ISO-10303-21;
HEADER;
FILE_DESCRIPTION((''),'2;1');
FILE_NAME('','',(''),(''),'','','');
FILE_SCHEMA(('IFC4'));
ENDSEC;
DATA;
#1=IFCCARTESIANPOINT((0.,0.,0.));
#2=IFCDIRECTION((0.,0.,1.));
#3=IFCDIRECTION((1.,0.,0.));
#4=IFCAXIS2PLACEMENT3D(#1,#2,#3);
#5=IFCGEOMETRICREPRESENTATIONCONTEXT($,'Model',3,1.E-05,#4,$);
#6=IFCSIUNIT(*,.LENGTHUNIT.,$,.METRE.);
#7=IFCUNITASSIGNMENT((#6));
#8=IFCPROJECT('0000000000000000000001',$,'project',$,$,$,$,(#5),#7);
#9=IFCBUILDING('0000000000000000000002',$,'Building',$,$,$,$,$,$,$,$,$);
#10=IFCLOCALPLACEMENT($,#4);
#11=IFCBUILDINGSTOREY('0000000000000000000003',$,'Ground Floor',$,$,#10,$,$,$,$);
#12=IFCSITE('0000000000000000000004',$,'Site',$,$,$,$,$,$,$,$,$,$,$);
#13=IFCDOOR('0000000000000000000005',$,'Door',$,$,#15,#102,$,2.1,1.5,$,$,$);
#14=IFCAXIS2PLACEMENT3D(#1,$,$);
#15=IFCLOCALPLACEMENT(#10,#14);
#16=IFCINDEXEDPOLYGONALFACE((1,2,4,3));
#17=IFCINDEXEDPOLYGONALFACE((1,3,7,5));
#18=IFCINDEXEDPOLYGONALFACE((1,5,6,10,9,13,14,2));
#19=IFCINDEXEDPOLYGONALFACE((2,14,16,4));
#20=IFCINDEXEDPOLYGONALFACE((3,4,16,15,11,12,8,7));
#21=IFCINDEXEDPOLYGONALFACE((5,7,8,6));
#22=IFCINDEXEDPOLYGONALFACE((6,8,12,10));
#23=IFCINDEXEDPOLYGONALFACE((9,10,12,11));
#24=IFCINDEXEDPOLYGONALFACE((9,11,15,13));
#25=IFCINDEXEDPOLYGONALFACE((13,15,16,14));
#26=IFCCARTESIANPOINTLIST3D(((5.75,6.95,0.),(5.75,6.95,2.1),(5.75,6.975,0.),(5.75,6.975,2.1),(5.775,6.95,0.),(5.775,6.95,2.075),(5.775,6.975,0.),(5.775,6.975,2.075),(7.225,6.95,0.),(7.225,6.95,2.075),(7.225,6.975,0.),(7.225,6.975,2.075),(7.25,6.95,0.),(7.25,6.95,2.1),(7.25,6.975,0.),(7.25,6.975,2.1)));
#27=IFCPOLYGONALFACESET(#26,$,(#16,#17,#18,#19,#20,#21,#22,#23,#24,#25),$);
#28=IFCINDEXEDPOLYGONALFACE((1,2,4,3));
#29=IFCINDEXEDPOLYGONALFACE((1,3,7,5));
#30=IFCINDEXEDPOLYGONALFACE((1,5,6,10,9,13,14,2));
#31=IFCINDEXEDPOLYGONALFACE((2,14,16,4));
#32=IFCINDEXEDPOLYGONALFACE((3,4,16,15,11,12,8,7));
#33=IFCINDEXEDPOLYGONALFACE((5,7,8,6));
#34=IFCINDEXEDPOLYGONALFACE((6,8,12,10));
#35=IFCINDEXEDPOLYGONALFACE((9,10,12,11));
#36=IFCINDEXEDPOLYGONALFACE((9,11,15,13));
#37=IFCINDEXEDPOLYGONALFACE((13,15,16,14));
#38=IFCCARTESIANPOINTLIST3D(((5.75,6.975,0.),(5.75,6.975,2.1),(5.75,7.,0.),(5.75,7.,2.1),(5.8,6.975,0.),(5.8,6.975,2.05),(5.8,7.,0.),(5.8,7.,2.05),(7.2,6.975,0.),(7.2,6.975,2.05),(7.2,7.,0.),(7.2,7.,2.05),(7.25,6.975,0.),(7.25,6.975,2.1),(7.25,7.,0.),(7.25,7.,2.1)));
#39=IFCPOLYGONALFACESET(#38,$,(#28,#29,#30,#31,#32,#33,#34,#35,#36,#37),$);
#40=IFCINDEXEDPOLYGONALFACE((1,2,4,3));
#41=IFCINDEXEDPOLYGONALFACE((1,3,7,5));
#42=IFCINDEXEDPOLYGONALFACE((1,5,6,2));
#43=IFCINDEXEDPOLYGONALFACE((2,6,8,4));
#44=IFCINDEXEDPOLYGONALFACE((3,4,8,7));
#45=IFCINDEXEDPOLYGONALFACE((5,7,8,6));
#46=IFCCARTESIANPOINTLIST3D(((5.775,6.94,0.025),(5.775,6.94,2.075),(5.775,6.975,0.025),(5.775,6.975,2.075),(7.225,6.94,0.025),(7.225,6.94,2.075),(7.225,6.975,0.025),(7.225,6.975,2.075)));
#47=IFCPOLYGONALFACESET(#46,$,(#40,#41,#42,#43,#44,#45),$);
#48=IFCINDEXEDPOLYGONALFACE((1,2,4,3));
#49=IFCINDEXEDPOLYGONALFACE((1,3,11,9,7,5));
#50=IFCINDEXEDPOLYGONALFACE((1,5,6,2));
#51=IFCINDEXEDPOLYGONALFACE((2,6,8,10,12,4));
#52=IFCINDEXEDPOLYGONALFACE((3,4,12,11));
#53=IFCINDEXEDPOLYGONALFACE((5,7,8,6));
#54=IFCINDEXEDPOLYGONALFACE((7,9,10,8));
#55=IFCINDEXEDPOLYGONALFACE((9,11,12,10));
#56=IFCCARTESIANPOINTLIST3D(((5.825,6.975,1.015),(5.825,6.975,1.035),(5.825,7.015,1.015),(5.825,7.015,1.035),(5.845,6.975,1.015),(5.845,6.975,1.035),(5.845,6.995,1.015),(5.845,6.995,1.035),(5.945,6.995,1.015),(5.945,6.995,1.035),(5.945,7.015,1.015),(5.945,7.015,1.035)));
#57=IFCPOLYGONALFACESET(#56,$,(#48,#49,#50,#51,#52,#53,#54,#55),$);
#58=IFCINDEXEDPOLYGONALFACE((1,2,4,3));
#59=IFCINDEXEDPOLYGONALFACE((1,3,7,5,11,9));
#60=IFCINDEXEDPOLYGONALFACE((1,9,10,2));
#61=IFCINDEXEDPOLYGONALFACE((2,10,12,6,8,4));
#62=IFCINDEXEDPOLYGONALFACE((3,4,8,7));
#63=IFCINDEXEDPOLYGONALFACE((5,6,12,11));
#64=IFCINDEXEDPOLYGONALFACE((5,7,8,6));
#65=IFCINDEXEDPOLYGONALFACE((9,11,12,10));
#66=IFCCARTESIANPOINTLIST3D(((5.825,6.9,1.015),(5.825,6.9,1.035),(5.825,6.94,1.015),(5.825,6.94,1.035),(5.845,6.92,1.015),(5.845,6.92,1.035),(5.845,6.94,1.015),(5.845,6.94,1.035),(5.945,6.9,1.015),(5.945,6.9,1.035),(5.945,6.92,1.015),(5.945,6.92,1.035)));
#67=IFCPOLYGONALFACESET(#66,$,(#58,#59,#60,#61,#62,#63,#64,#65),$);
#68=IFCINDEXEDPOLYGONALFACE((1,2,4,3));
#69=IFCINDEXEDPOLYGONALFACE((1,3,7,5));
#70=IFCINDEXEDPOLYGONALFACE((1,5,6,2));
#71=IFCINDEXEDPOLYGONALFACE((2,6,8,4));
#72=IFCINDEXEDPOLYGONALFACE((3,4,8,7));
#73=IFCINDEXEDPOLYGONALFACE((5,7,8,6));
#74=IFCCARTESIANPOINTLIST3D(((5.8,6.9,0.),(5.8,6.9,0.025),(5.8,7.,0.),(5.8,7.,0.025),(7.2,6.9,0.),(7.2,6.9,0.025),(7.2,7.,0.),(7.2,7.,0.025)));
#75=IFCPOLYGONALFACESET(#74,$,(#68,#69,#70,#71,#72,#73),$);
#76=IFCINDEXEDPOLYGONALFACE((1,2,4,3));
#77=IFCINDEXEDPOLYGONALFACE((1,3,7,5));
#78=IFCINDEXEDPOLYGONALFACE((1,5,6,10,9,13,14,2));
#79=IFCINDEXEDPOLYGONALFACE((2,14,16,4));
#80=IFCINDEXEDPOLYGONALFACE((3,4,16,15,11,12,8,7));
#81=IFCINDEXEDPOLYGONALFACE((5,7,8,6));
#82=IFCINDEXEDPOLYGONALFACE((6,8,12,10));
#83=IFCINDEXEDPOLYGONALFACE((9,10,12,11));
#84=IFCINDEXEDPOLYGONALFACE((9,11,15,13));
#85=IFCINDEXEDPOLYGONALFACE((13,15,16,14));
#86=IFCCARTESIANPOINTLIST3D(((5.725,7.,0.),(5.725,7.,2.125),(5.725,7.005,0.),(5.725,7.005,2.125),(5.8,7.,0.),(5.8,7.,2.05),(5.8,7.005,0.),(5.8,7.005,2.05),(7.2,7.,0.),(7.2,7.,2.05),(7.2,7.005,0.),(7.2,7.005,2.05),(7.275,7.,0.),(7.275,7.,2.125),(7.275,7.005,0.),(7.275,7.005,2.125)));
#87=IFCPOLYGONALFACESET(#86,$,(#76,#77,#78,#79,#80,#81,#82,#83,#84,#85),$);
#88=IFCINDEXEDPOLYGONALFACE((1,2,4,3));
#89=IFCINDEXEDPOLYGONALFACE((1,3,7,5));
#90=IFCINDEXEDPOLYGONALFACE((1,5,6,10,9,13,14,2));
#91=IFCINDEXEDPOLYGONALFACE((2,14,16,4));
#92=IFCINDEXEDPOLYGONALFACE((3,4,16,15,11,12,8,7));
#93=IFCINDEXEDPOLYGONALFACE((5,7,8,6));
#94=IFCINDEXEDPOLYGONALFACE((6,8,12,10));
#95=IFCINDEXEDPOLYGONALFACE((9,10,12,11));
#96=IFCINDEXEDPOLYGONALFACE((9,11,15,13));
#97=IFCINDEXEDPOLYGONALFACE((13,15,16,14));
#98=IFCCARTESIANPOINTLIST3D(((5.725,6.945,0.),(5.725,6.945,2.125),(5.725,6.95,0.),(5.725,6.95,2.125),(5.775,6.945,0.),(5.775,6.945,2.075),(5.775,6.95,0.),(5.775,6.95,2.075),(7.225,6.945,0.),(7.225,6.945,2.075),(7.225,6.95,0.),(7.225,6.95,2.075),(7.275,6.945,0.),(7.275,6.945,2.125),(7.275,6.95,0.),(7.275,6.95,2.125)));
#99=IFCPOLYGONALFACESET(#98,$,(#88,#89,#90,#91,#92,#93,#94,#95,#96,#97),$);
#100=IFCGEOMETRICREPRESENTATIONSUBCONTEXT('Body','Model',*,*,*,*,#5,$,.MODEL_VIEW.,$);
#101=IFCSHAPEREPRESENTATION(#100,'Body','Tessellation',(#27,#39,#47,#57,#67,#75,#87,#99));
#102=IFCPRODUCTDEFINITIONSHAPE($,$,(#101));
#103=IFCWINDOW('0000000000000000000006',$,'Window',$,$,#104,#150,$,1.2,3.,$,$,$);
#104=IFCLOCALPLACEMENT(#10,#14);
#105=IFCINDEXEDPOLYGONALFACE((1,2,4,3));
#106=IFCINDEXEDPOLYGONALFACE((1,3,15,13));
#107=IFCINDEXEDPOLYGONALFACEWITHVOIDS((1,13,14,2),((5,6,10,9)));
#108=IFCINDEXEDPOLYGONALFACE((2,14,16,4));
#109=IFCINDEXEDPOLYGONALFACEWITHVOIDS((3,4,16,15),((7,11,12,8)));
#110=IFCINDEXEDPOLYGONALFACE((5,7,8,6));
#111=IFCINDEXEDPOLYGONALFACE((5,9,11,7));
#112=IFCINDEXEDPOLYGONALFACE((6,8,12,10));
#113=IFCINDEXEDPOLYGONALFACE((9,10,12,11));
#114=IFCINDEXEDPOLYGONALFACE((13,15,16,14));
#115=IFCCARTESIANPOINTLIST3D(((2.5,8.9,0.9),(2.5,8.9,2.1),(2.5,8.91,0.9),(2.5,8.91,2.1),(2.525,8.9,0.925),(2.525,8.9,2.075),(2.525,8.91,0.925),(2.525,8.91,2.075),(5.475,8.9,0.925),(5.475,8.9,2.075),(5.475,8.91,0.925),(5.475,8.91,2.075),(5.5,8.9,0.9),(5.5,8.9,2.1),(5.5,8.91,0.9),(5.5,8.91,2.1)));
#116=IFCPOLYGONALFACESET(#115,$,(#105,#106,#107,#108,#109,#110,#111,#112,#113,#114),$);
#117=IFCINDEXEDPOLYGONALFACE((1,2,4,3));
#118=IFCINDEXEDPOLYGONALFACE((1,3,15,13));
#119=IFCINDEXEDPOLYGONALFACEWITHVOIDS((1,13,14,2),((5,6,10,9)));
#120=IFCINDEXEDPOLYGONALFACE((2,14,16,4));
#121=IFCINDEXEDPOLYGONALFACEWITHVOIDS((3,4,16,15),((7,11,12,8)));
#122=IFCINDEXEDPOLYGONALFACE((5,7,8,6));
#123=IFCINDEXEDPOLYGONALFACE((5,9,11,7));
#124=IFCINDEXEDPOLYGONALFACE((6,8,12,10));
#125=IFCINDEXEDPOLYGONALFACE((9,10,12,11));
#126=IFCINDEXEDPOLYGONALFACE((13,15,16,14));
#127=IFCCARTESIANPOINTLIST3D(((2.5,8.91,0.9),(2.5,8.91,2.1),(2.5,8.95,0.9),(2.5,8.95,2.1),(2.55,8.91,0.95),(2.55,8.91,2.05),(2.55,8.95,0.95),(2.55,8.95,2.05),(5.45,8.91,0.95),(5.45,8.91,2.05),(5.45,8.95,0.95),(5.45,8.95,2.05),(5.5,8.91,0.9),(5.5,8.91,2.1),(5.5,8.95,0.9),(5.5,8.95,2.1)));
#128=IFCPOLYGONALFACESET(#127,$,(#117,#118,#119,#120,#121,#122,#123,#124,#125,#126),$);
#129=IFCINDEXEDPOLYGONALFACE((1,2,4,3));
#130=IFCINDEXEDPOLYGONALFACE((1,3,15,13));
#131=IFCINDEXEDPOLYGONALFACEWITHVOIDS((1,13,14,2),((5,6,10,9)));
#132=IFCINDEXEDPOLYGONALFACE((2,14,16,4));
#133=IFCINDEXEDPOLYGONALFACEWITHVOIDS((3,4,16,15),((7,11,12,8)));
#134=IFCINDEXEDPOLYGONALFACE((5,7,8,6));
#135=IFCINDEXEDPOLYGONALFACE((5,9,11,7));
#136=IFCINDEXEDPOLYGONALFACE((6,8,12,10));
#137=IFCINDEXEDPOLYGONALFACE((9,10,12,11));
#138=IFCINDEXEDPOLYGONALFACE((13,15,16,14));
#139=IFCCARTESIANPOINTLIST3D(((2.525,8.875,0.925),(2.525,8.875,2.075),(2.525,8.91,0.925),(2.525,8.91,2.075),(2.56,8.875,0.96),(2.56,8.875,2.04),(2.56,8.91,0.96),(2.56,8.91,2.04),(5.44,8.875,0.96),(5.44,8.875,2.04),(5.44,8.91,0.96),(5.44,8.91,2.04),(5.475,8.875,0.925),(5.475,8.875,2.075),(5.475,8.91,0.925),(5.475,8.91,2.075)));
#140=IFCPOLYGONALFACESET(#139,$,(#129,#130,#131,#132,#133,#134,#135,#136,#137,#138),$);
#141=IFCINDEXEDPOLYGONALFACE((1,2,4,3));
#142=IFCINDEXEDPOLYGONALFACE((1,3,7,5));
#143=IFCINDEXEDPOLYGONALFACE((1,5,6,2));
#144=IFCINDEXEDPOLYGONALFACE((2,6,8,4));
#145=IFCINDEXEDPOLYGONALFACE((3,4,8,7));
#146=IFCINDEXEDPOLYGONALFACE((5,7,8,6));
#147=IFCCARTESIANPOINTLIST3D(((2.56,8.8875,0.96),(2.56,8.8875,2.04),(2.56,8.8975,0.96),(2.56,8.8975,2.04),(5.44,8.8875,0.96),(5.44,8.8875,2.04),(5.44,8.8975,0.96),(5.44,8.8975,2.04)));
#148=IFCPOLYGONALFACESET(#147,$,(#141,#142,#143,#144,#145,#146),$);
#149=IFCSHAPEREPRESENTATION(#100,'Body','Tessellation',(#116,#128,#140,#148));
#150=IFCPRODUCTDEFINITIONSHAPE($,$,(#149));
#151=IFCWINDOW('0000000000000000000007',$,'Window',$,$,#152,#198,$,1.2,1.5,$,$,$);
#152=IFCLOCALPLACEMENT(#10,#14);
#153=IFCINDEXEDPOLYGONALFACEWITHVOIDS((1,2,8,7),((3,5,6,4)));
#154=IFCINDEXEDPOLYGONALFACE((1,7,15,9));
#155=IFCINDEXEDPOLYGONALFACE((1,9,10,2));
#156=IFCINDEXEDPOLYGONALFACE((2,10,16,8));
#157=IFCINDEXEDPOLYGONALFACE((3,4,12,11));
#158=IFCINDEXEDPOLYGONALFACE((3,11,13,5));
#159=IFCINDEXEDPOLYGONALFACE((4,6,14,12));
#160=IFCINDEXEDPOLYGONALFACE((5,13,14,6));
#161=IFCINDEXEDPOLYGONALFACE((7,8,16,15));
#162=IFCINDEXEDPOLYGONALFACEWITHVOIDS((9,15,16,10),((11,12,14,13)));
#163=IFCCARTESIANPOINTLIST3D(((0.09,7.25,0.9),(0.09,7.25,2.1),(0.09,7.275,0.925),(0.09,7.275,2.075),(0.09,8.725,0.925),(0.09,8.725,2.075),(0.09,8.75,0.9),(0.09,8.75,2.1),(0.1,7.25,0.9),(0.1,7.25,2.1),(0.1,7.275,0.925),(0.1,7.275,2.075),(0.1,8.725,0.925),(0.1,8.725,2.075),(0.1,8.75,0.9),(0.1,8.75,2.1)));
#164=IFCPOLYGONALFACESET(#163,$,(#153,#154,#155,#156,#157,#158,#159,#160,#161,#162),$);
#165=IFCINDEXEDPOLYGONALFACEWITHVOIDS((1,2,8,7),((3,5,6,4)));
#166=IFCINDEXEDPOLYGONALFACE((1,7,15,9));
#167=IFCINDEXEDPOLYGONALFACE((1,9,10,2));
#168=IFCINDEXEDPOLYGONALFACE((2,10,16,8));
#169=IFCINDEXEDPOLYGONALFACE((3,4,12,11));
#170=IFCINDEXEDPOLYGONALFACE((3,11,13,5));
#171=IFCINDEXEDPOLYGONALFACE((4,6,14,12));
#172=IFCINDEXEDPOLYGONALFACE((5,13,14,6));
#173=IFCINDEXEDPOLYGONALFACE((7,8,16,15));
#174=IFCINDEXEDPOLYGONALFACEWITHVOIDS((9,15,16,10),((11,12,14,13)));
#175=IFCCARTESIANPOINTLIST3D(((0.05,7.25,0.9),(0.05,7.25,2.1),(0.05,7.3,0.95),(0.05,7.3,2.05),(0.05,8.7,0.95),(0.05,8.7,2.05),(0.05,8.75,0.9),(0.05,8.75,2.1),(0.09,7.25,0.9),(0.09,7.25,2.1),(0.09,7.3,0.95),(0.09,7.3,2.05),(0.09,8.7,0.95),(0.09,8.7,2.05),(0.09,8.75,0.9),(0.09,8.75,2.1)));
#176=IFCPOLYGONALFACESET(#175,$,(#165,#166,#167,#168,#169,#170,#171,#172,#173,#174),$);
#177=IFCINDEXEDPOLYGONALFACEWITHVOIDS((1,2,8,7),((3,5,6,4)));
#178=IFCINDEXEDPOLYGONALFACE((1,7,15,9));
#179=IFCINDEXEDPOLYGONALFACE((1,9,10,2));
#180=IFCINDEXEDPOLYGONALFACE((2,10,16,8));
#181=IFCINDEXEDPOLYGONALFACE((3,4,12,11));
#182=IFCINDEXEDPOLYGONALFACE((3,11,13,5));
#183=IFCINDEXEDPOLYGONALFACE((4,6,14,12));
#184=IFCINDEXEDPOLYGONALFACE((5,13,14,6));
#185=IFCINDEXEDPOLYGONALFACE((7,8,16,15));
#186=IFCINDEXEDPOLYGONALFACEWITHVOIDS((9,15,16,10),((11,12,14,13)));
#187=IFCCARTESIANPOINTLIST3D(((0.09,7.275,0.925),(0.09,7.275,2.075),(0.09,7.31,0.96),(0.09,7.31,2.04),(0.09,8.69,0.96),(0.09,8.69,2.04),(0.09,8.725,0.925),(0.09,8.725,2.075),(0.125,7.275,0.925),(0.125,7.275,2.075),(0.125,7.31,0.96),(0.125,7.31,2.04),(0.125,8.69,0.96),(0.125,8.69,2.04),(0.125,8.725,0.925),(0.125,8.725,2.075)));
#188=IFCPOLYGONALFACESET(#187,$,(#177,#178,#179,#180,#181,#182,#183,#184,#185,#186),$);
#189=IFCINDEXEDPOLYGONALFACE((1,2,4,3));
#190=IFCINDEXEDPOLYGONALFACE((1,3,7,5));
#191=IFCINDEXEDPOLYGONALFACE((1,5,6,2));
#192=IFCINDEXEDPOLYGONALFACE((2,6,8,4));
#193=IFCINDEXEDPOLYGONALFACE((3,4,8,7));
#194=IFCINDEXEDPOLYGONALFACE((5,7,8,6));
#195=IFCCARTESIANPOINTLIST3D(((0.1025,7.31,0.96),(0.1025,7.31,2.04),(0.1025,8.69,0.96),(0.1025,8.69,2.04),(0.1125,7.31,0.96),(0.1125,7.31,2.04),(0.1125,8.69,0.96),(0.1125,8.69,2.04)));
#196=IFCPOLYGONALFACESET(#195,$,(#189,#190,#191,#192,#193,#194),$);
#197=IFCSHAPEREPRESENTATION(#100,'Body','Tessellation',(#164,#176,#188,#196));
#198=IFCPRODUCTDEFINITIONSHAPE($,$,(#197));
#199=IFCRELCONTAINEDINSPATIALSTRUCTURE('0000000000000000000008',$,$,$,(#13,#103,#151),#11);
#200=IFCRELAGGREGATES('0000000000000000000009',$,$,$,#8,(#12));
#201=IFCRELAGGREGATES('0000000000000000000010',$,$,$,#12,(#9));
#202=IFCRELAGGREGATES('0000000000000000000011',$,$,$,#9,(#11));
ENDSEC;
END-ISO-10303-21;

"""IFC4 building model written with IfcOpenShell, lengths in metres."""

from ifc_helpers import new_model, si_unit, frame, origin_with_axes, place, context, subcontext, project, spatial, line, indexed_curve, outline, extrude, element, save


model = new_model("IFC4")

# Units and contexts
model_context = context("Model", 3, precision=1e-05, world=origin_with_axes())
body_context = subcontext(model_context, "Body", "Model", "MODEL_VIEW")
ifc_project = project(units=[si_unit("LENGTHUNIT", "METRE")], contexts=[model_context])

# Site, building, storey
site = spatial("IfcSite", under=ifc_project, Name="Site")
building = spatial("IfcBuilding", under=site, Name="Building")
storey_placement = place(None, origin_with_axes())
storey = spatial("IfcBuildingStorey", under=building, at=storey_placement, Name="Ground Floor")

# Door
door_1_placement = place(storey_placement, frame((7.25, 7.0, 0.0), z_axis=(0.0, 0.0, 1.0), x_axis=(-1.0, 0.0, 0.0)))
element("IfcDoor", 1, at=door_1_placement, inside=storey, Name="Door", OverallHeight=2.1, OverallWidth=1.5, context=body_context, shape_type="SweptSolid", body=[
    extrude(outline(indexed_curve([(0.0, 0.0), (0.0, 2.1), (1.5, 2.1), (1.5, 0.0), (1.475, 0.0), (1.475, 2.075), (0.025, 2.075), (0.025, 0.0)], segments=[line(1, 2, 3, 4, 5, 6, 7, 8, 1)])), frame((0.0, 0.025, 0.0), z_axis=(0.0, -1.0, 0.0), x_axis=(1.0, 0.0, 0.0)), (0.0, 0.0, -1.0), 0.025),
    extrude(outline(indexed_curve([(0.0, 0.0), (0.0, 2.1), (1.5, 2.1), (1.5, 0.0), (1.45, 0.0), (1.45, 2.05), (0.05, 2.05), (0.05, 0.0)], segments=[line(1, 2, 3, 4, 5, 6, 7, 8, 1)])), frame((0.0, 0.0, 0.0), z_axis=(0.0, -1.0, 0.0), x_axis=(1.0, 0.0, 0.0)), (0.0, 0.0, -1.0), 0.025),
    extrude(outline(indexed_curve([(0.0, 0.0), (1.45, 0.0), (1.45, 0.035), (0.0, 0.035)], segments=[line(1, 2, 3, 4, 1)])), frame((0.025, 0.025, 0.025), z_axis=(0.0, 0.0, 1.0), x_axis=(1.0, 0.0, 0.0)), (0.0, 0.0, 1.0), 2.05),
    extrude(outline(indexed_curve([(0.0, 0.0), (0.0, -0.04), (-0.12, -0.04), (-0.12, -0.02), (-0.02, -0.02), (-0.02, 0.0)], segments=[line(1, 2, 3, 4, 5, 6, 1)])), frame((1.425, 0.025, 1.015), z_axis=(0.0, 0.0, 1.0), x_axis=(1.0, 0.0, 0.0)), (0.0, 0.0, 1.0), 0.02),
    extrude(outline(indexed_curve([(0.0, 0.0), (0.0, 0.04), (-0.12, 0.04), (-0.12, 0.02), (-0.02, 0.02), (-0.02, 0.0)], segments=[line(1, 2, 3, 4, 5, 6, 1)])), frame((1.425, 0.06, 1.015), z_axis=(0.0, 0.0, 1.0), x_axis=(1.0, 0.0, 0.0)), (0.0, 0.0, 1.0), 0.02),
    extrude(outline(indexed_curve([(0.0, 0.0), (1.4, 0.0), (1.4, 0.1), (0.0, 0.1)], segments=[line(1, 2, 3, 4, 1)])), frame((0.05, 0.0, 0.0), z_axis=(0.0, 0.0, 1.0), x_axis=(1.0, 0.0, 0.0)), (0.0, 0.0, 1.0), 0.025),
    extrude(outline(indexed_curve([(0.0, 0.0), (0.0, 2.125), (1.55, 2.125), (1.55, 0.0), (1.475, 0.0), (1.475, 2.05), (0.075, 2.05), (0.075, 0.0)], segments=[line(1, 2, 3, 4, 5, 6, 7, 8, 1)])), frame((-0.025, -0.005, 0.0), z_axis=(0.0, -1.0, 0.0), x_axis=(1.0, 0.0, 0.0)), (0.0, 0.0, -1.0), 0.005),
    extrude(outline(indexed_curve([(0.0, 0.0), (0.0, 2.125), (1.55, 2.125), (1.55, 0.0), (1.5, 0.0), (1.5, 2.075), (0.05, 2.075), (0.05, 0.0)], segments=[line(1, 2, 3, 4, 5, 6, 7, 8, 1)])), frame((-0.025, 0.05, 0.0), z_axis=(0.0, -1.0, 0.0), x_axis=(1.0, 0.0, 0.0)), (0.0, 0.0, -1.0), 0.005),
])

# Windows
window_placement = place(storey_placement, frame((5.5, 9.0, 0.9), z_axis=(0.0, 0.0, 1.0), x_axis=(-1.0, 0.0, 0.0)))
element("IfcWindow", 2, at=window_placement, inside=storey, Name="Window", OverallHeight=1.2, OverallWidth=3.0, context=body_context, shape_type="SweptSolid", body=[
    extrude(outline(indexed_curve([(0.0, 0.0), (3.0, 0.0), (3.0, 1.2), (0.0, 1.2)], segments=[line(1, 2, 3, 4, 1)]), holes=[indexed_curve([(0.025, 0.025), (2.975, 0.025), (2.975, 1.175), (0.025, 1.175)], segments=[line(1, 2, 3, 4, 1)])]), frame((0.0, 0.09, 0.0), z_axis=(0.0, -1.0, 0.0), x_axis=(1.0, 0.0, 0.0)), (0.0, 0.0, -1.0), 0.01),
    extrude(outline(indexed_curve([(0.0, 0.0), (3.0, 0.0), (3.0, 1.2), (0.0, 1.2)], segments=[line(1, 2, 3, 4, 1)]), holes=[indexed_curve([(0.05, 0.05), (2.95, 0.05), (2.95, 1.15), (0.05, 1.15)], segments=[line(1, 2, 3, 4, 1)])]), frame((0.0, 0.05, 0.0), z_axis=(0.0, -1.0, 0.0), x_axis=(1.0, 0.0, 0.0)), (0.0, 0.0, -1.0), 0.04),
    extrude(outline(indexed_curve([(0.0, 0.0), (2.95, 0.0), (2.95, 1.15), (0.0, 1.15)], segments=[line(1, 2, 3, 4, 1)]), holes=[indexed_curve([(0.035, 0.035), (2.915, 0.035), (2.915, 1.115), (0.035, 1.115)], segments=[line(1, 2, 3, 4, 1)])]), frame((0.025, 0.09, 0.025), z_axis=(0.0, -1.0, 0.0), x_axis=(1.0, 0.0, 0.0)), (0.0, 0.0, -1.0), 0.035),
    extrude(outline(indexed_curve([(0.035, 0.035), (2.915, 0.035), (2.915, 1.115), (0.035, 1.115)], segments=[line(1, 2, 3, 4, 1)])), frame((0.025, 0.1025, 0.025), z_axis=(0.0, -1.0, 0.0), x_axis=(1.0, 0.0, 0.0)), (0.0, 0.0, -1.0), 0.01),
])
for number, where, z_axis, x_axis, name in (
    (3, (0.0, 8.75, 0.9), (0.0, 0.0, 1.0), (0.0, -1.0, 0.0), "Window"),
):
    element("IfcWindow", number, at=place(storey_placement, frame(where, z_axis=z_axis, x_axis=x_axis)), inside=storey, Name=name, OverallHeight=1.2, OverallWidth=1.5, context=body_context, shape_type="SweptSolid", body=[
        extrude(outline(indexed_curve([(0.0, 0.0), (1.5, 0.0), (1.5, 1.2), (0.0, 1.2)], segments=[line(1, 2, 3, 4, 1)]), holes=[indexed_curve([(0.025, 0.025), (1.475, 0.025), (1.475, 1.175), (0.025, 1.175)], segments=[line(1, 2, 3, 4, 1)])]), frame((0.0, 0.09, 0.0), z_axis=(0.0, -1.0, 0.0), x_axis=(1.0, 0.0, 0.0)), (0.0, 0.0, -1.0), 0.01),
        extrude(outline(indexed_curve([(0.0, 0.0), (1.5, 0.0), (1.5, 1.2), (0.0, 1.2)], segments=[line(1, 2, 3, 4, 1)]), holes=[indexed_curve([(0.05, 0.05), (1.45, 0.05), (1.45, 1.15), (0.05, 1.15)], segments=[line(1, 2, 3, 4, 1)])]), frame((0.0, 0.05, 0.0), z_axis=(0.0, -1.0, 0.0), x_axis=(1.0, 0.0, 0.0)), (0.0, 0.0, -1.0), 0.04),
        extrude(outline(indexed_curve([(0.0, 0.0), (1.45, 0.0), (1.45, 1.15), (0.0, 1.15)], segments=[line(1, 2, 3, 4, 1)]), holes=[indexed_curve([(0.035, 0.035), (1.415, 0.035), (1.415, 1.115), (0.035, 1.115)], segments=[line(1, 2, 3, 4, 1)])]), frame((0.025, 0.09, 0.025), z_axis=(0.0, -1.0, 0.0), x_axis=(1.0, 0.0, 0.0)), (0.0, 0.0, -1.0), 0.035),
        extrude(outline(indexed_curve([(0.035, 0.035), (1.415, 0.035), (1.415, 1.115), (0.035, 1.115)], segments=[line(1, 2, 3, 4, 1)])), frame((0.025, 0.1025, 0.025), z_axis=(0.0, -1.0, 0.0), x_axis=(1.0, 0.0, 0.0)), (0.0, 0.0, -1.0), 0.01),
    ])

save(model, "model.ifc")
